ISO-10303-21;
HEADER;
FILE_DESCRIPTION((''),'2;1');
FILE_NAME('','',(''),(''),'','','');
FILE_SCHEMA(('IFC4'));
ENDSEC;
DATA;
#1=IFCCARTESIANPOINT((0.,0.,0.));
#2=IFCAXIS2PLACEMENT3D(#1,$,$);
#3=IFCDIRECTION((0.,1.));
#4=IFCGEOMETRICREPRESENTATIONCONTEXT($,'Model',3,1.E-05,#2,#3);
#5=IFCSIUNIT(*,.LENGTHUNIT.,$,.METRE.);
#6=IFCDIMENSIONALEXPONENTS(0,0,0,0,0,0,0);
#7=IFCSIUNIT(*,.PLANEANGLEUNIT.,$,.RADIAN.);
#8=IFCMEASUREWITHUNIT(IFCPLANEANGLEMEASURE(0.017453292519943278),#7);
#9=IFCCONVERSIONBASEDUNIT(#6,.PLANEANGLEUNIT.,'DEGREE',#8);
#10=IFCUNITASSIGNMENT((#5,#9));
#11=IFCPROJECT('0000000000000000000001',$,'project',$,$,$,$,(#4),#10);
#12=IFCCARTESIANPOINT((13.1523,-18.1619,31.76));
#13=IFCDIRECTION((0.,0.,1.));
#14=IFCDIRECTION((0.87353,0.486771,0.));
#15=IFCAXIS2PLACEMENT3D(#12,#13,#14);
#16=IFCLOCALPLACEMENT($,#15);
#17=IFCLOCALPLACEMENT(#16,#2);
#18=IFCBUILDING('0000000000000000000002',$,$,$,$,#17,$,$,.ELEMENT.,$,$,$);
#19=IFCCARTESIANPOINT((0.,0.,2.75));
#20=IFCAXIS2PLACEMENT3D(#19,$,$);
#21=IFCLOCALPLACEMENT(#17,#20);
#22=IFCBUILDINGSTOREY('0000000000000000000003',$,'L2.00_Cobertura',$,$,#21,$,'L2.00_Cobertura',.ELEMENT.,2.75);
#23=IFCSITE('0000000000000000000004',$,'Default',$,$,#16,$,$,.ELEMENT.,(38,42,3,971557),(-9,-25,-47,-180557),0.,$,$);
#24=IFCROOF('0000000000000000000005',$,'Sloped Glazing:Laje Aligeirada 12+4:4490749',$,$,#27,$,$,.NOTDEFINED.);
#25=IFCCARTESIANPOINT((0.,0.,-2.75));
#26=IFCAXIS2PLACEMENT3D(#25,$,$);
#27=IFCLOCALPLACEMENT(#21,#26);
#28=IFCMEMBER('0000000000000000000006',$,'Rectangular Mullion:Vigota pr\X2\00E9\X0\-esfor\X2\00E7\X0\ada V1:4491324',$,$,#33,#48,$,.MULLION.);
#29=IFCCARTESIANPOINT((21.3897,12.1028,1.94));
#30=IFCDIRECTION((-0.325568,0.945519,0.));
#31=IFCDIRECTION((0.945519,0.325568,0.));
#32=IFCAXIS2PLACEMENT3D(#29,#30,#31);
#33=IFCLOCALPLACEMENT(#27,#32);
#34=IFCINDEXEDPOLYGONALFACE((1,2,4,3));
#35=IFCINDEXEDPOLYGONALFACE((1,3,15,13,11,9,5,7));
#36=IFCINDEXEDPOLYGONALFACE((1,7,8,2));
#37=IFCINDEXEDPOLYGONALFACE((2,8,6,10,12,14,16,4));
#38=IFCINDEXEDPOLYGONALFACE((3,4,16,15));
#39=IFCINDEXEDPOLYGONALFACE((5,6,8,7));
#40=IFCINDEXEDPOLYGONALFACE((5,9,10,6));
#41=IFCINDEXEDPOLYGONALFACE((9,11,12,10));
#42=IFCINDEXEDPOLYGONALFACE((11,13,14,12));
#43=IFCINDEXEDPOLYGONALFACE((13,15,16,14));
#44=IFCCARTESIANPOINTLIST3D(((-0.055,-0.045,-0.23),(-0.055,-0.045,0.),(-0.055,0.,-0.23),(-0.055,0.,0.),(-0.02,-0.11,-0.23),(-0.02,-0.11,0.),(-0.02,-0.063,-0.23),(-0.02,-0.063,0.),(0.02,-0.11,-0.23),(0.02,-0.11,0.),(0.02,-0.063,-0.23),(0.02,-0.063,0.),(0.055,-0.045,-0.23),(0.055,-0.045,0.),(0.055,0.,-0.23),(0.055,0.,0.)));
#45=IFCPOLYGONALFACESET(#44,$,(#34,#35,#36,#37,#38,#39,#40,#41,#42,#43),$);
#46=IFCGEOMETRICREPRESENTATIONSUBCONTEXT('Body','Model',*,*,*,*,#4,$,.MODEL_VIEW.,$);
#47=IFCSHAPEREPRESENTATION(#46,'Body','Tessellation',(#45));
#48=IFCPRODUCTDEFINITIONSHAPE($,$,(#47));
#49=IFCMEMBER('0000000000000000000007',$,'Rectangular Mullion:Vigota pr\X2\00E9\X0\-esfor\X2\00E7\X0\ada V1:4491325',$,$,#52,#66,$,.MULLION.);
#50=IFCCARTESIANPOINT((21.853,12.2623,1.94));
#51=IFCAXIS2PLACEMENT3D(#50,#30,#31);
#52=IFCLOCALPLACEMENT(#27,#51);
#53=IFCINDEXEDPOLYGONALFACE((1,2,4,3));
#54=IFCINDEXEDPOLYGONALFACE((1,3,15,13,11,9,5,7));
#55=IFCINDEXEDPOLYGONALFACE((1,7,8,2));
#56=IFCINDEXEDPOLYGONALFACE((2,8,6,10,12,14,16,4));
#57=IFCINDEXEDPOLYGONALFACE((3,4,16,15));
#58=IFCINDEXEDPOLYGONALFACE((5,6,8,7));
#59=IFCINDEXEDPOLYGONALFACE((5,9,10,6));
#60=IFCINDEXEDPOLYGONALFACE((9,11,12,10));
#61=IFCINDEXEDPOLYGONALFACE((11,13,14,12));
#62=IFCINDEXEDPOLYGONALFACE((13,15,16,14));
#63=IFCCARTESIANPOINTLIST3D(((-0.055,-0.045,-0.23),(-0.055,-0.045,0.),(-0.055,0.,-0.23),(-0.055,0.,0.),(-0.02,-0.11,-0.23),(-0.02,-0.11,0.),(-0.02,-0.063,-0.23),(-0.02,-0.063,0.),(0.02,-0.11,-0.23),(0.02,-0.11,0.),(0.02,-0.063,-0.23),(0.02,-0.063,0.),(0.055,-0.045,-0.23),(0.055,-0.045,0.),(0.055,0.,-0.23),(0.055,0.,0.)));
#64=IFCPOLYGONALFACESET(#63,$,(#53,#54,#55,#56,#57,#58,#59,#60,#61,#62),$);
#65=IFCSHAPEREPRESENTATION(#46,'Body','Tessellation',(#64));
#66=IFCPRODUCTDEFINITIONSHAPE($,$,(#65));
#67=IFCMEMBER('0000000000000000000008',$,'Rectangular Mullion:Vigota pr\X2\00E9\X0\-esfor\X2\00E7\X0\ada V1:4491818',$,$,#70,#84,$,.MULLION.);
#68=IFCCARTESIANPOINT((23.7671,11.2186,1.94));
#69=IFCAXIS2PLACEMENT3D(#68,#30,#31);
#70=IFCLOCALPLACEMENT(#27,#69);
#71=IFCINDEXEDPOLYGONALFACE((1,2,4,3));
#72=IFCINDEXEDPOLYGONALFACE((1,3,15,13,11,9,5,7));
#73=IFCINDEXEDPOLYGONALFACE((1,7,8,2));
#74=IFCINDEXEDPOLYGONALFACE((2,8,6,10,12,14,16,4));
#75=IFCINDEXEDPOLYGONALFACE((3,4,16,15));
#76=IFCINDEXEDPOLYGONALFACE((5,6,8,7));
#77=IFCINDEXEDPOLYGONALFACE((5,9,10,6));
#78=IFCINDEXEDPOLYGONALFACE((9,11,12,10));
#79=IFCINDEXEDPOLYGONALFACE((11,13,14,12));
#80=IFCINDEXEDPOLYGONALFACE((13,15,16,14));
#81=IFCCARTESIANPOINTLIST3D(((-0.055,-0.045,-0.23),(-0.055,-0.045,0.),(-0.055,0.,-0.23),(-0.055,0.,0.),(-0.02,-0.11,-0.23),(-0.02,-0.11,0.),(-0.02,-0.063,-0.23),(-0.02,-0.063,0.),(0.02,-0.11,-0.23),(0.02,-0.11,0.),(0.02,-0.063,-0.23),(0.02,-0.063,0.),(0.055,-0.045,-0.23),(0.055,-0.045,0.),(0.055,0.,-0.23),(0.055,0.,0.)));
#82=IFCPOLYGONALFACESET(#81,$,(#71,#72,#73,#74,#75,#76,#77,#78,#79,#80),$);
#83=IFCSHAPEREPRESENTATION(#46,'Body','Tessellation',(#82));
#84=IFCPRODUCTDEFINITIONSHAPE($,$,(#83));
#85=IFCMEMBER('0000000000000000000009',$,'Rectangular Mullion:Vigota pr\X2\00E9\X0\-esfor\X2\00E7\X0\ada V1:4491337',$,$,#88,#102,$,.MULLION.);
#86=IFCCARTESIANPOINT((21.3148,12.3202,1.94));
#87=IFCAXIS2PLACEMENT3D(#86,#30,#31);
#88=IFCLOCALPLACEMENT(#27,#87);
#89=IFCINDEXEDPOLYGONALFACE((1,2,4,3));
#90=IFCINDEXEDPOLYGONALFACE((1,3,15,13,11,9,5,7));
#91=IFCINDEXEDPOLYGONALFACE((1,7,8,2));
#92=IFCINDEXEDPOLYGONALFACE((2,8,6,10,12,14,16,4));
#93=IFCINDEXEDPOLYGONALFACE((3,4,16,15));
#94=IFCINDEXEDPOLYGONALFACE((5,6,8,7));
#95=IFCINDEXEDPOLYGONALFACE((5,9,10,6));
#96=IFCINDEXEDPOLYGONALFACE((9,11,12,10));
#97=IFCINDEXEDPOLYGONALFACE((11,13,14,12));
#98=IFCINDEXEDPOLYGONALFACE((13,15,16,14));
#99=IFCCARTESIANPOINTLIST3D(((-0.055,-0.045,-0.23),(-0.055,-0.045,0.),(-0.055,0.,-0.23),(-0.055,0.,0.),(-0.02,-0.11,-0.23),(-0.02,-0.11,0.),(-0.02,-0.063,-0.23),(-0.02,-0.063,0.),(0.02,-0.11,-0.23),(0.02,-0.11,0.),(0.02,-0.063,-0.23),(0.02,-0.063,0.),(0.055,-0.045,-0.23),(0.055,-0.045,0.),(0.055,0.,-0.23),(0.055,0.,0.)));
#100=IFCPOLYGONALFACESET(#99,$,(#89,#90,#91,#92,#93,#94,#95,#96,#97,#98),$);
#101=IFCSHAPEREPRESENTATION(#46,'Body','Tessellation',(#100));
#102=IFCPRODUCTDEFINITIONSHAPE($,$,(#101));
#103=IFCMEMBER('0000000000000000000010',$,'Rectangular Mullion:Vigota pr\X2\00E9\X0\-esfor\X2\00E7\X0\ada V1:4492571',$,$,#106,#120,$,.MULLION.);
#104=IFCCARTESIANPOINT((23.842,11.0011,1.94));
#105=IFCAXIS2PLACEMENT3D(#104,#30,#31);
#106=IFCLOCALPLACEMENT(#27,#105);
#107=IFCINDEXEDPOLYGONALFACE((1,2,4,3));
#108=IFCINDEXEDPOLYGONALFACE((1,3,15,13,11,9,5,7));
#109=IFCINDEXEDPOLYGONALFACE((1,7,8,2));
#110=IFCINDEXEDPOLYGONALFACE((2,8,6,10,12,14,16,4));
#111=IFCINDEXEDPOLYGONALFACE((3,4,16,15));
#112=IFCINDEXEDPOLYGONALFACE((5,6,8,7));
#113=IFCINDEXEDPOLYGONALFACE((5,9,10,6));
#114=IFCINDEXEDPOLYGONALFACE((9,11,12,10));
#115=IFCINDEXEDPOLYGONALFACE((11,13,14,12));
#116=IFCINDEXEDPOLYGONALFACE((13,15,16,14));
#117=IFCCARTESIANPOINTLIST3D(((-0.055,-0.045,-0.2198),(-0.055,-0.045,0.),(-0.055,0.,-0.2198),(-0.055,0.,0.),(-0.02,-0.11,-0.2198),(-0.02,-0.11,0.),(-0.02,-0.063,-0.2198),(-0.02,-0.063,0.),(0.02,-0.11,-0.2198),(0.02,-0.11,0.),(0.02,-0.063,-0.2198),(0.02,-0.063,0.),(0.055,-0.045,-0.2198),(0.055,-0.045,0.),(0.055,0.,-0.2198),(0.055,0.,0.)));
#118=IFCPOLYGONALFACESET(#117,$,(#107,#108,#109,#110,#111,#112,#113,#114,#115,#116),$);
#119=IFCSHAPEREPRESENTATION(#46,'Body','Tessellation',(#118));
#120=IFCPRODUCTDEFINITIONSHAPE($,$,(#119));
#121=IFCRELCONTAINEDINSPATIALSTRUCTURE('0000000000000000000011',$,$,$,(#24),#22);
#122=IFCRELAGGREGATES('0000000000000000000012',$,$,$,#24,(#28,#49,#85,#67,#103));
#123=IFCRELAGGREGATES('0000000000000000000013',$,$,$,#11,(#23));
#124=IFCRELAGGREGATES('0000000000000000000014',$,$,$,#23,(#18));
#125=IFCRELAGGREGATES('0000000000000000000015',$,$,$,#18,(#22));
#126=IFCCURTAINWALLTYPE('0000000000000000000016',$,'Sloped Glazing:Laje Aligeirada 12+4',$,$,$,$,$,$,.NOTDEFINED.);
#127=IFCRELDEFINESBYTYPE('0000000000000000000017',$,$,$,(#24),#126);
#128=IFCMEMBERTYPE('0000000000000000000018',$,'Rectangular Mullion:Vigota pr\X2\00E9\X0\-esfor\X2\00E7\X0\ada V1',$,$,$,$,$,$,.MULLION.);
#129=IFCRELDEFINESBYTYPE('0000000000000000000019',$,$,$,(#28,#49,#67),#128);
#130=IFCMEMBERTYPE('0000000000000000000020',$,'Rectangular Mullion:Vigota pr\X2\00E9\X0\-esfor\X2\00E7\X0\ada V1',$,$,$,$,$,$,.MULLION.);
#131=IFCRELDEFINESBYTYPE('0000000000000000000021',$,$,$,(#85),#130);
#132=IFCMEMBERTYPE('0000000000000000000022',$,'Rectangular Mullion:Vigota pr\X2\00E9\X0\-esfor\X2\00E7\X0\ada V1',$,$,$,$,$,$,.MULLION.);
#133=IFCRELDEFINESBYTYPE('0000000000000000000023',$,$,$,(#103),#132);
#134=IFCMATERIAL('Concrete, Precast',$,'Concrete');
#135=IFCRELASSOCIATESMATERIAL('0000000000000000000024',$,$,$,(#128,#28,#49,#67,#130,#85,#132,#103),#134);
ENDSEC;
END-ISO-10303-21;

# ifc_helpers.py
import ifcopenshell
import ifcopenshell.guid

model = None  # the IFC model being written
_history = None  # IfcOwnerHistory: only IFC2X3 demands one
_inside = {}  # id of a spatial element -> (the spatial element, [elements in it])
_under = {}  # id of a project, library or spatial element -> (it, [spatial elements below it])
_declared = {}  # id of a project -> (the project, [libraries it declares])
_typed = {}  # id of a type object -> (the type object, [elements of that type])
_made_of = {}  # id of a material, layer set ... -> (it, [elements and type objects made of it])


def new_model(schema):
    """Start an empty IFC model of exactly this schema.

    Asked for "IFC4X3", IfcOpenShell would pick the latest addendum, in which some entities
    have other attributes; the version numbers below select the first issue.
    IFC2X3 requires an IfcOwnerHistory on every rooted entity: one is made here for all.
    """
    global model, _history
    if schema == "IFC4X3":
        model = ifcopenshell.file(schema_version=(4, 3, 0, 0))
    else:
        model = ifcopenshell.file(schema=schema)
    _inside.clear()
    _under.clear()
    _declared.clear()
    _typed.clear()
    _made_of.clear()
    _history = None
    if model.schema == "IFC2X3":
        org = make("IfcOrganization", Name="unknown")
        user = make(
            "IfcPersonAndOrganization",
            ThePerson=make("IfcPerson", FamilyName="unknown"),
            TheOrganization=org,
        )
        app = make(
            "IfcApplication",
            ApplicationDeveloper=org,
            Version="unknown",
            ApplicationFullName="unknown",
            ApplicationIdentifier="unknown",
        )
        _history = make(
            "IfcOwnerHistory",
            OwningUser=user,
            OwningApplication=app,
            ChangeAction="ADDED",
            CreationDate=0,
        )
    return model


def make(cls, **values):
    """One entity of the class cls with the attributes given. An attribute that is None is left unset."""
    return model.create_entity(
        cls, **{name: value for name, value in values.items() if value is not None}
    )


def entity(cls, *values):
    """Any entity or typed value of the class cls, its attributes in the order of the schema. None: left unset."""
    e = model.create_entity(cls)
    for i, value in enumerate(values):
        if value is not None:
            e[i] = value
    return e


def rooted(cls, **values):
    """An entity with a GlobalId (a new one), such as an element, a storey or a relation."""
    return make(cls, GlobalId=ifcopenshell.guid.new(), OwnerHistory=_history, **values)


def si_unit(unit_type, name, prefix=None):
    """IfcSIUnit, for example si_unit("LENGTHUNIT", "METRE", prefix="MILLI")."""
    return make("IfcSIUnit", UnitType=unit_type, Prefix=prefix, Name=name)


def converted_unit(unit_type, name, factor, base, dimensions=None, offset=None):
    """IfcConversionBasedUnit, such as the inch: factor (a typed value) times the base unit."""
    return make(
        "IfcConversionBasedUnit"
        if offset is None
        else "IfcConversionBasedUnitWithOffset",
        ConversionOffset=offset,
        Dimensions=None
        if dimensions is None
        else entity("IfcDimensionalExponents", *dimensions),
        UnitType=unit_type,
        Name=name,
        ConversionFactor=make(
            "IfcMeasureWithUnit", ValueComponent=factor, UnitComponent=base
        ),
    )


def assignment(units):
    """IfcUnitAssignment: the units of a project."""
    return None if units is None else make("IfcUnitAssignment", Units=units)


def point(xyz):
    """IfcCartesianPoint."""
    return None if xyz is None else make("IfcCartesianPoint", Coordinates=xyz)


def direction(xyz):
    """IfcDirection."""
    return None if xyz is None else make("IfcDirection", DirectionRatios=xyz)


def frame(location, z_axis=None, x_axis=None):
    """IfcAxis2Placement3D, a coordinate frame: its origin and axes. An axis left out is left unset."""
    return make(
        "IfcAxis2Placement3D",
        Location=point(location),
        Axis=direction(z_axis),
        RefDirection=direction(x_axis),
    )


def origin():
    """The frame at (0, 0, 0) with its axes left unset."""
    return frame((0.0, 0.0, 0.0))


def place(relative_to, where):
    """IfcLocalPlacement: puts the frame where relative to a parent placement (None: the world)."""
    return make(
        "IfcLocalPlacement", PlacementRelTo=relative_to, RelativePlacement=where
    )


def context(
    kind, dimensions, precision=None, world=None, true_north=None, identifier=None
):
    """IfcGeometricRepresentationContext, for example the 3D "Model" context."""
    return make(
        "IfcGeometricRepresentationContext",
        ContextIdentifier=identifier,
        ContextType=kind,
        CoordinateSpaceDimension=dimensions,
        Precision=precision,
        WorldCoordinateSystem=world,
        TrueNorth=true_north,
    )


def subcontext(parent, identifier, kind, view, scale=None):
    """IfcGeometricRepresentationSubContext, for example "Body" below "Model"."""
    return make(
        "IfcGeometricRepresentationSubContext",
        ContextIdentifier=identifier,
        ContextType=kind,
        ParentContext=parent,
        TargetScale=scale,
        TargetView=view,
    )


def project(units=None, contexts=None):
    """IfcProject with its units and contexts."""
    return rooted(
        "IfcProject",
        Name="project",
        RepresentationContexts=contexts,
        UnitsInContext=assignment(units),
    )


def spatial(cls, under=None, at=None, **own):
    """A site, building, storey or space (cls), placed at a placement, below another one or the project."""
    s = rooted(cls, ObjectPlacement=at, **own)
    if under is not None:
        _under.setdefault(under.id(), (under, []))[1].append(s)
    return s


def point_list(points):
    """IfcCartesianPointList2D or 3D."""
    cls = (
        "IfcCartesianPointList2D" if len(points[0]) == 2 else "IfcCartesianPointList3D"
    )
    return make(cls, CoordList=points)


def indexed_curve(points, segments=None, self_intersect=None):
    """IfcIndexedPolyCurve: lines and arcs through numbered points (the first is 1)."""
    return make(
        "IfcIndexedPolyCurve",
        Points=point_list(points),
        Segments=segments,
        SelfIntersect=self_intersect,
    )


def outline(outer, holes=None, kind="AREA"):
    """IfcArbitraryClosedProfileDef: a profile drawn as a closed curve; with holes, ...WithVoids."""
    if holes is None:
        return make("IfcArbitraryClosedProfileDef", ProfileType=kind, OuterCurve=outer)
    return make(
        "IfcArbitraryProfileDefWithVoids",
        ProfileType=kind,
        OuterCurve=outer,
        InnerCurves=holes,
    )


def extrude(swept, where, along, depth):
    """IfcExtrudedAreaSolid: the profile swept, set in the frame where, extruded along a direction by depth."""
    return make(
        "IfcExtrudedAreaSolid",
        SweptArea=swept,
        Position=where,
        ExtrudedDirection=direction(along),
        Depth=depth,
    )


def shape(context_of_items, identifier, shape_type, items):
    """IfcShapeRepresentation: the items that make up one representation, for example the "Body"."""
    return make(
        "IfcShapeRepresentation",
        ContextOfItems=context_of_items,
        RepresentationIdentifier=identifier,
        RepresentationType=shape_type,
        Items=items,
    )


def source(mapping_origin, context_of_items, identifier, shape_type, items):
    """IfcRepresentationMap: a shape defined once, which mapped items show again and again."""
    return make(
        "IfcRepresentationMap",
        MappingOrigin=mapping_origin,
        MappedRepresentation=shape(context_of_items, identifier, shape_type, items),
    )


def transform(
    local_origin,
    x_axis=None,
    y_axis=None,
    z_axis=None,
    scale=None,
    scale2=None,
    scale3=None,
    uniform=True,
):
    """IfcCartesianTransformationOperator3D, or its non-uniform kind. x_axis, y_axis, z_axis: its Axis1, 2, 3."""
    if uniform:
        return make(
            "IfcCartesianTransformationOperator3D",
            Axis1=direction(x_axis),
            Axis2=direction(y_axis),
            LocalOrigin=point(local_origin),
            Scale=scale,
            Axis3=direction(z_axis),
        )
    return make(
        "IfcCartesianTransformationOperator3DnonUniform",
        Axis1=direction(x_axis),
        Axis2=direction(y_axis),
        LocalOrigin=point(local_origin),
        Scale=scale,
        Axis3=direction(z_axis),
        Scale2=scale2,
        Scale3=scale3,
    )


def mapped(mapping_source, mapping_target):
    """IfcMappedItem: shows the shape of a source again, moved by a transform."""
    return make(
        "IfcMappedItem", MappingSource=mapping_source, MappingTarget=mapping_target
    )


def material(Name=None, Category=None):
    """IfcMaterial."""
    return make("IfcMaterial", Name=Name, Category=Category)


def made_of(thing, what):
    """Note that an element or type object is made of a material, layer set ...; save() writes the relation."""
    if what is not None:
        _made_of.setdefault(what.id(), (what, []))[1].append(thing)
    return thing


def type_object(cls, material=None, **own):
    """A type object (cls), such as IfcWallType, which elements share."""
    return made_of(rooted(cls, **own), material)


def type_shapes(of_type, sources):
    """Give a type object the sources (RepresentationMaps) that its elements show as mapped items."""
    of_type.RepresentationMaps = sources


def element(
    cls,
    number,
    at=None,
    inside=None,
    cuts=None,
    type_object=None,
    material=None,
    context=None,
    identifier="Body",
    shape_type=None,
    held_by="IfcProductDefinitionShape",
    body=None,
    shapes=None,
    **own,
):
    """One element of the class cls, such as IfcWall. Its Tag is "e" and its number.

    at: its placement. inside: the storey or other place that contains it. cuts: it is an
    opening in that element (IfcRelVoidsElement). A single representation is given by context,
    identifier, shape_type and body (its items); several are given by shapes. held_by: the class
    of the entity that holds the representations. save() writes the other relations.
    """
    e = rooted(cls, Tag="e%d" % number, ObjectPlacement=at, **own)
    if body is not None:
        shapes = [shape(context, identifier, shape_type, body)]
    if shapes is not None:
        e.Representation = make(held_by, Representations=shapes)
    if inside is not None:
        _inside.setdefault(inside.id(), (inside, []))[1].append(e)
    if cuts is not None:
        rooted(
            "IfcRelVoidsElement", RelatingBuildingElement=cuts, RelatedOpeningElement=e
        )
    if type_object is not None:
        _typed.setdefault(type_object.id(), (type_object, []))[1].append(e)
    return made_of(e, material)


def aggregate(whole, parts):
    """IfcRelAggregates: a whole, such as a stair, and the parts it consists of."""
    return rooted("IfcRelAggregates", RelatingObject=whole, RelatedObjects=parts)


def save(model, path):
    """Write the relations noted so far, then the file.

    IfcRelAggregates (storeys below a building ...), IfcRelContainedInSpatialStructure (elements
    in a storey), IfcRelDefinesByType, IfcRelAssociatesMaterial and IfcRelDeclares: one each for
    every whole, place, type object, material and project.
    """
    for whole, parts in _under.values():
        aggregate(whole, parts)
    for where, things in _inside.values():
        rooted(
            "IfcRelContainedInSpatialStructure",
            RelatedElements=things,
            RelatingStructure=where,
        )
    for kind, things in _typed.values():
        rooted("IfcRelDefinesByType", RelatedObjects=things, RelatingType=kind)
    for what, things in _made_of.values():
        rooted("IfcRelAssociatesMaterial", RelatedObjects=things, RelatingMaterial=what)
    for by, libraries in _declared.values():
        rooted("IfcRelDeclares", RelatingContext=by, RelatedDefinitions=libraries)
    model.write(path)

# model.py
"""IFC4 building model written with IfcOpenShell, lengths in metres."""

from ifc_helpers import new_model, entity, si_unit, converted_unit, direction, frame, origin, place, context, subcontext, project, spatial, indexed_curve, outline, extrude, source, transform, mapped, material, type_object, type_shapes, element, aggregate, save


model = new_model("IFC4")

# Units and contexts
model_context = context("Model", 3, precision=1e-05, world=origin(), true_north=direction((0.0, 1.0)))
body_context = subcontext(model_context, "Body", "Model", "MODEL_VIEW")
ifc_project = project(units=[si_unit("LENGTHUNIT", "METRE"), converted_unit("PLANEANGLEUNIT", "DEGREE", entity("IfcPlaneAngleMeasure", 0.017453292519943278), si_unit("PLANEANGLEUNIT", "RADIAN"), dimensions=[0, 0, 0, 0, 0, 0, 0])], contexts=[model_context])

# Site, building, storey
site_placement = place(None, frame((13.1523, -18.1619, 31.76), z_axis=(0.0, 0.0, 1.0), x_axis=(0.87353, 0.486771, 0.0)))
site = spatial("IfcSite", under=ifc_project, at=site_placement, Name="Default", CompositionType="ELEMENT", RefLatitude=(38, 42, 3, 971557), RefLongitude=(-9, -25, -47, -180557), RefElevation=0.0)
building_placement = place(site_placement, origin())
building = spatial("IfcBuilding", under=site, at=building_placement, CompositionType="ELEMENT")
storey_placement = place(building_placement, frame((0.0, 0.0, 2.75)))
storey = spatial("IfcBuildingStorey", under=building, at=storey_placement, Name="L2.00_Cobertura", LongName="L2.00_Cobertura", CompositionType="ELEMENT", Elevation=2.75)

# Roof, members
curtain_wall_type = type_object("IfcCurtainWallType", Name="Sloped Glazing:Laje Aligeirada 12+4", PredefinedType="NOTDEFINED")
roof_placement = place(storey_placement, frame((0.0, 0.0, -2.75)))
roof = element("IfcRoof", 1, at=roof_placement, inside=storey, type_object=curtain_wall_type, Name="Sloped Glazing:Laje Aligeirada 12+4:4490749", PredefinedType="NOTDEFINED")
ifc_material_1 = material(Name="Concrete, Precast", Category="Concrete")
member_type_1 = type_object("IfcMemberType", Name="Rectangular Mullion:Vigota pré-esforçada V1", PredefinedType="MULLION", material=ifc_material_1)
shared_shape_1 = source(origin(), body_context, "Body", "SweptSolid", [
    extrude(outline(indexed_curve([(-0.055, -0.0545), (0.055, -0.0545), (0.055, -0.0095), (0.02, 0.0085), (0.02, 0.0555), (-0.02, 0.0555), (-0.02, 0.0085), (-0.055, -0.0095), (-0.055, -0.0545)], self_intersect=False)), frame((0.0, -0.0545, -0.23), z_axis=(0.0, 0.0, 1.0), x_axis=(-1.0, 0.0, 0.0)), (0.0, 0.0, 1.0), 0.23),
])
type_shapes(member_type_1, [shared_shape_1])
member_1_placement = place(roof_placement, frame((21.3897, 12.1028, 1.94), z_axis=(-0.325568, 0.945519, 0.0), x_axis=(0.945519, 0.325568, 0.0)))
member_1 = element("IfcMember", 2, at=member_1_placement, type_object=member_type_1, material=ifc_material_1, Name="Rectangular Mullion:Vigota pré-esforçada V1:4491324", PredefinedType="MULLION", context=body_context, shape_type="MappedRepresentation", body=[
    mapped(shared_shape_1, transform((0.0, 0.0, 0.0), scale=1.0)),
])
member_2_placement = place(roof_placement, frame((21.853, 12.2623, 1.94), z_axis=(-0.325568, 0.945519, 0.0), x_axis=(0.945519, 0.325568, 0.0)))
member_2 = element("IfcMember", 3, at=member_2_placement, type_object=member_type_1, material=ifc_material_1, Name="Rectangular Mullion:Vigota pré-esforçada V1:4491325", PredefinedType="MULLION", context=body_context, shape_type="MappedRepresentation", body=[
    mapped(shared_shape_1, transform((0.0, 0.0, 0.0), scale=1.0)),
])
member_3_placement = place(roof_placement, frame((23.7671, 11.2186, 1.94), z_axis=(-0.325568, 0.945519, 0.0), x_axis=(0.945519, 0.325568, 0.0)))
member_3 = element("IfcMember", 4, at=member_3_placement, type_object=member_type_1, material=ifc_material_1, Name="Rectangular Mullion:Vigota pré-esforçada V1:4491818", PredefinedType="MULLION", context=body_context, shape_type="MappedRepresentation", body=[
    mapped(shared_shape_1, transform((0.0, 0.0, 0.0), scale=1.0)),
])
member_type_2 = type_object("IfcMemberType", Name="Rectangular Mullion:Vigota pré-esforçada V1", PredefinedType="MULLION", material=ifc_material_1)
shared_shape_2 = source(origin(), body_context, "Body", "SweptSolid", [
    extrude(outline(indexed_curve([(-0.055, -0.0545), (0.055, -0.0545), (0.055, -0.0095), (0.02, 0.0085), (0.02, 0.0555), (-0.02, 0.0555), (-0.02, 0.0085), (-0.055, -0.0095), (-0.055, -0.0545)], self_intersect=False)), frame((0.0, -0.0545, -0.23), z_axis=(0.0, 0.0, 1.0), x_axis=(-1.0, 0.0, 0.0)), (0.0, 0.0, 1.0), 0.23),
])
type_shapes(member_type_2, [shared_shape_2])
member_4_placement = place(roof_placement, frame((21.3148, 12.3202, 1.94), z_axis=(-0.325568, 0.945519, 0.0), x_axis=(0.945519, 0.325568, 0.0)))
member_4 = element("IfcMember", 5, at=member_4_placement, type_object=member_type_2, material=ifc_material_1, Name="Rectangular Mullion:Vigota pré-esforçada V1:4491337", PredefinedType="MULLION", context=body_context, shape_type="MappedRepresentation", body=[
    mapped(shared_shape_2, transform((0.0, 0.0, 0.0), scale=1.0)),
])
member_type_3 = type_object("IfcMemberType", Name="Rectangular Mullion:Vigota pré-esforçada V1", PredefinedType="MULLION", material=ifc_material_1)
shared_shape_3 = source(origin(), body_context, "Body", "SweptSolid", [
    extrude(outline(indexed_curve([(-0.055, -0.0545), (0.055, -0.0545), (0.055, -0.0095), (0.02, 0.0085), (0.02, 0.0555), (-0.02, 0.0555), (-0.02, 0.0085), (-0.055, -0.0095), (-0.055, -0.0545)], self_intersect=False)), frame((0.0, -0.0545, -0.2198), z_axis=(0.0, 0.0, 1.0), x_axis=(-1.0, 0.0, 0.0)), (0.0, 0.0, 1.0), 0.2198),
])
type_shapes(member_type_3, [shared_shape_3])
member_5_placement = place(roof_placement, frame((23.842, 11.0011, 1.94), z_axis=(-0.325568, 0.945519, 0.0), x_axis=(0.945519, 0.325568, 0.0)))
member_5 = element("IfcMember", 6, at=member_5_placement, type_object=member_type_3, material=ifc_material_1, Name="Rectangular Mullion:Vigota pré-esforçada V1:4492571", PredefinedType="MULLION", context=body_context, shape_type="MappedRepresentation", body=[
    mapped(shared_shape_3, transform((0.0, 0.0, 0.0), scale=1.0)),
])
aggregate(roof, [member_1, member_2, member_4, member_3, member_5])

save(model, "model.ifc")
